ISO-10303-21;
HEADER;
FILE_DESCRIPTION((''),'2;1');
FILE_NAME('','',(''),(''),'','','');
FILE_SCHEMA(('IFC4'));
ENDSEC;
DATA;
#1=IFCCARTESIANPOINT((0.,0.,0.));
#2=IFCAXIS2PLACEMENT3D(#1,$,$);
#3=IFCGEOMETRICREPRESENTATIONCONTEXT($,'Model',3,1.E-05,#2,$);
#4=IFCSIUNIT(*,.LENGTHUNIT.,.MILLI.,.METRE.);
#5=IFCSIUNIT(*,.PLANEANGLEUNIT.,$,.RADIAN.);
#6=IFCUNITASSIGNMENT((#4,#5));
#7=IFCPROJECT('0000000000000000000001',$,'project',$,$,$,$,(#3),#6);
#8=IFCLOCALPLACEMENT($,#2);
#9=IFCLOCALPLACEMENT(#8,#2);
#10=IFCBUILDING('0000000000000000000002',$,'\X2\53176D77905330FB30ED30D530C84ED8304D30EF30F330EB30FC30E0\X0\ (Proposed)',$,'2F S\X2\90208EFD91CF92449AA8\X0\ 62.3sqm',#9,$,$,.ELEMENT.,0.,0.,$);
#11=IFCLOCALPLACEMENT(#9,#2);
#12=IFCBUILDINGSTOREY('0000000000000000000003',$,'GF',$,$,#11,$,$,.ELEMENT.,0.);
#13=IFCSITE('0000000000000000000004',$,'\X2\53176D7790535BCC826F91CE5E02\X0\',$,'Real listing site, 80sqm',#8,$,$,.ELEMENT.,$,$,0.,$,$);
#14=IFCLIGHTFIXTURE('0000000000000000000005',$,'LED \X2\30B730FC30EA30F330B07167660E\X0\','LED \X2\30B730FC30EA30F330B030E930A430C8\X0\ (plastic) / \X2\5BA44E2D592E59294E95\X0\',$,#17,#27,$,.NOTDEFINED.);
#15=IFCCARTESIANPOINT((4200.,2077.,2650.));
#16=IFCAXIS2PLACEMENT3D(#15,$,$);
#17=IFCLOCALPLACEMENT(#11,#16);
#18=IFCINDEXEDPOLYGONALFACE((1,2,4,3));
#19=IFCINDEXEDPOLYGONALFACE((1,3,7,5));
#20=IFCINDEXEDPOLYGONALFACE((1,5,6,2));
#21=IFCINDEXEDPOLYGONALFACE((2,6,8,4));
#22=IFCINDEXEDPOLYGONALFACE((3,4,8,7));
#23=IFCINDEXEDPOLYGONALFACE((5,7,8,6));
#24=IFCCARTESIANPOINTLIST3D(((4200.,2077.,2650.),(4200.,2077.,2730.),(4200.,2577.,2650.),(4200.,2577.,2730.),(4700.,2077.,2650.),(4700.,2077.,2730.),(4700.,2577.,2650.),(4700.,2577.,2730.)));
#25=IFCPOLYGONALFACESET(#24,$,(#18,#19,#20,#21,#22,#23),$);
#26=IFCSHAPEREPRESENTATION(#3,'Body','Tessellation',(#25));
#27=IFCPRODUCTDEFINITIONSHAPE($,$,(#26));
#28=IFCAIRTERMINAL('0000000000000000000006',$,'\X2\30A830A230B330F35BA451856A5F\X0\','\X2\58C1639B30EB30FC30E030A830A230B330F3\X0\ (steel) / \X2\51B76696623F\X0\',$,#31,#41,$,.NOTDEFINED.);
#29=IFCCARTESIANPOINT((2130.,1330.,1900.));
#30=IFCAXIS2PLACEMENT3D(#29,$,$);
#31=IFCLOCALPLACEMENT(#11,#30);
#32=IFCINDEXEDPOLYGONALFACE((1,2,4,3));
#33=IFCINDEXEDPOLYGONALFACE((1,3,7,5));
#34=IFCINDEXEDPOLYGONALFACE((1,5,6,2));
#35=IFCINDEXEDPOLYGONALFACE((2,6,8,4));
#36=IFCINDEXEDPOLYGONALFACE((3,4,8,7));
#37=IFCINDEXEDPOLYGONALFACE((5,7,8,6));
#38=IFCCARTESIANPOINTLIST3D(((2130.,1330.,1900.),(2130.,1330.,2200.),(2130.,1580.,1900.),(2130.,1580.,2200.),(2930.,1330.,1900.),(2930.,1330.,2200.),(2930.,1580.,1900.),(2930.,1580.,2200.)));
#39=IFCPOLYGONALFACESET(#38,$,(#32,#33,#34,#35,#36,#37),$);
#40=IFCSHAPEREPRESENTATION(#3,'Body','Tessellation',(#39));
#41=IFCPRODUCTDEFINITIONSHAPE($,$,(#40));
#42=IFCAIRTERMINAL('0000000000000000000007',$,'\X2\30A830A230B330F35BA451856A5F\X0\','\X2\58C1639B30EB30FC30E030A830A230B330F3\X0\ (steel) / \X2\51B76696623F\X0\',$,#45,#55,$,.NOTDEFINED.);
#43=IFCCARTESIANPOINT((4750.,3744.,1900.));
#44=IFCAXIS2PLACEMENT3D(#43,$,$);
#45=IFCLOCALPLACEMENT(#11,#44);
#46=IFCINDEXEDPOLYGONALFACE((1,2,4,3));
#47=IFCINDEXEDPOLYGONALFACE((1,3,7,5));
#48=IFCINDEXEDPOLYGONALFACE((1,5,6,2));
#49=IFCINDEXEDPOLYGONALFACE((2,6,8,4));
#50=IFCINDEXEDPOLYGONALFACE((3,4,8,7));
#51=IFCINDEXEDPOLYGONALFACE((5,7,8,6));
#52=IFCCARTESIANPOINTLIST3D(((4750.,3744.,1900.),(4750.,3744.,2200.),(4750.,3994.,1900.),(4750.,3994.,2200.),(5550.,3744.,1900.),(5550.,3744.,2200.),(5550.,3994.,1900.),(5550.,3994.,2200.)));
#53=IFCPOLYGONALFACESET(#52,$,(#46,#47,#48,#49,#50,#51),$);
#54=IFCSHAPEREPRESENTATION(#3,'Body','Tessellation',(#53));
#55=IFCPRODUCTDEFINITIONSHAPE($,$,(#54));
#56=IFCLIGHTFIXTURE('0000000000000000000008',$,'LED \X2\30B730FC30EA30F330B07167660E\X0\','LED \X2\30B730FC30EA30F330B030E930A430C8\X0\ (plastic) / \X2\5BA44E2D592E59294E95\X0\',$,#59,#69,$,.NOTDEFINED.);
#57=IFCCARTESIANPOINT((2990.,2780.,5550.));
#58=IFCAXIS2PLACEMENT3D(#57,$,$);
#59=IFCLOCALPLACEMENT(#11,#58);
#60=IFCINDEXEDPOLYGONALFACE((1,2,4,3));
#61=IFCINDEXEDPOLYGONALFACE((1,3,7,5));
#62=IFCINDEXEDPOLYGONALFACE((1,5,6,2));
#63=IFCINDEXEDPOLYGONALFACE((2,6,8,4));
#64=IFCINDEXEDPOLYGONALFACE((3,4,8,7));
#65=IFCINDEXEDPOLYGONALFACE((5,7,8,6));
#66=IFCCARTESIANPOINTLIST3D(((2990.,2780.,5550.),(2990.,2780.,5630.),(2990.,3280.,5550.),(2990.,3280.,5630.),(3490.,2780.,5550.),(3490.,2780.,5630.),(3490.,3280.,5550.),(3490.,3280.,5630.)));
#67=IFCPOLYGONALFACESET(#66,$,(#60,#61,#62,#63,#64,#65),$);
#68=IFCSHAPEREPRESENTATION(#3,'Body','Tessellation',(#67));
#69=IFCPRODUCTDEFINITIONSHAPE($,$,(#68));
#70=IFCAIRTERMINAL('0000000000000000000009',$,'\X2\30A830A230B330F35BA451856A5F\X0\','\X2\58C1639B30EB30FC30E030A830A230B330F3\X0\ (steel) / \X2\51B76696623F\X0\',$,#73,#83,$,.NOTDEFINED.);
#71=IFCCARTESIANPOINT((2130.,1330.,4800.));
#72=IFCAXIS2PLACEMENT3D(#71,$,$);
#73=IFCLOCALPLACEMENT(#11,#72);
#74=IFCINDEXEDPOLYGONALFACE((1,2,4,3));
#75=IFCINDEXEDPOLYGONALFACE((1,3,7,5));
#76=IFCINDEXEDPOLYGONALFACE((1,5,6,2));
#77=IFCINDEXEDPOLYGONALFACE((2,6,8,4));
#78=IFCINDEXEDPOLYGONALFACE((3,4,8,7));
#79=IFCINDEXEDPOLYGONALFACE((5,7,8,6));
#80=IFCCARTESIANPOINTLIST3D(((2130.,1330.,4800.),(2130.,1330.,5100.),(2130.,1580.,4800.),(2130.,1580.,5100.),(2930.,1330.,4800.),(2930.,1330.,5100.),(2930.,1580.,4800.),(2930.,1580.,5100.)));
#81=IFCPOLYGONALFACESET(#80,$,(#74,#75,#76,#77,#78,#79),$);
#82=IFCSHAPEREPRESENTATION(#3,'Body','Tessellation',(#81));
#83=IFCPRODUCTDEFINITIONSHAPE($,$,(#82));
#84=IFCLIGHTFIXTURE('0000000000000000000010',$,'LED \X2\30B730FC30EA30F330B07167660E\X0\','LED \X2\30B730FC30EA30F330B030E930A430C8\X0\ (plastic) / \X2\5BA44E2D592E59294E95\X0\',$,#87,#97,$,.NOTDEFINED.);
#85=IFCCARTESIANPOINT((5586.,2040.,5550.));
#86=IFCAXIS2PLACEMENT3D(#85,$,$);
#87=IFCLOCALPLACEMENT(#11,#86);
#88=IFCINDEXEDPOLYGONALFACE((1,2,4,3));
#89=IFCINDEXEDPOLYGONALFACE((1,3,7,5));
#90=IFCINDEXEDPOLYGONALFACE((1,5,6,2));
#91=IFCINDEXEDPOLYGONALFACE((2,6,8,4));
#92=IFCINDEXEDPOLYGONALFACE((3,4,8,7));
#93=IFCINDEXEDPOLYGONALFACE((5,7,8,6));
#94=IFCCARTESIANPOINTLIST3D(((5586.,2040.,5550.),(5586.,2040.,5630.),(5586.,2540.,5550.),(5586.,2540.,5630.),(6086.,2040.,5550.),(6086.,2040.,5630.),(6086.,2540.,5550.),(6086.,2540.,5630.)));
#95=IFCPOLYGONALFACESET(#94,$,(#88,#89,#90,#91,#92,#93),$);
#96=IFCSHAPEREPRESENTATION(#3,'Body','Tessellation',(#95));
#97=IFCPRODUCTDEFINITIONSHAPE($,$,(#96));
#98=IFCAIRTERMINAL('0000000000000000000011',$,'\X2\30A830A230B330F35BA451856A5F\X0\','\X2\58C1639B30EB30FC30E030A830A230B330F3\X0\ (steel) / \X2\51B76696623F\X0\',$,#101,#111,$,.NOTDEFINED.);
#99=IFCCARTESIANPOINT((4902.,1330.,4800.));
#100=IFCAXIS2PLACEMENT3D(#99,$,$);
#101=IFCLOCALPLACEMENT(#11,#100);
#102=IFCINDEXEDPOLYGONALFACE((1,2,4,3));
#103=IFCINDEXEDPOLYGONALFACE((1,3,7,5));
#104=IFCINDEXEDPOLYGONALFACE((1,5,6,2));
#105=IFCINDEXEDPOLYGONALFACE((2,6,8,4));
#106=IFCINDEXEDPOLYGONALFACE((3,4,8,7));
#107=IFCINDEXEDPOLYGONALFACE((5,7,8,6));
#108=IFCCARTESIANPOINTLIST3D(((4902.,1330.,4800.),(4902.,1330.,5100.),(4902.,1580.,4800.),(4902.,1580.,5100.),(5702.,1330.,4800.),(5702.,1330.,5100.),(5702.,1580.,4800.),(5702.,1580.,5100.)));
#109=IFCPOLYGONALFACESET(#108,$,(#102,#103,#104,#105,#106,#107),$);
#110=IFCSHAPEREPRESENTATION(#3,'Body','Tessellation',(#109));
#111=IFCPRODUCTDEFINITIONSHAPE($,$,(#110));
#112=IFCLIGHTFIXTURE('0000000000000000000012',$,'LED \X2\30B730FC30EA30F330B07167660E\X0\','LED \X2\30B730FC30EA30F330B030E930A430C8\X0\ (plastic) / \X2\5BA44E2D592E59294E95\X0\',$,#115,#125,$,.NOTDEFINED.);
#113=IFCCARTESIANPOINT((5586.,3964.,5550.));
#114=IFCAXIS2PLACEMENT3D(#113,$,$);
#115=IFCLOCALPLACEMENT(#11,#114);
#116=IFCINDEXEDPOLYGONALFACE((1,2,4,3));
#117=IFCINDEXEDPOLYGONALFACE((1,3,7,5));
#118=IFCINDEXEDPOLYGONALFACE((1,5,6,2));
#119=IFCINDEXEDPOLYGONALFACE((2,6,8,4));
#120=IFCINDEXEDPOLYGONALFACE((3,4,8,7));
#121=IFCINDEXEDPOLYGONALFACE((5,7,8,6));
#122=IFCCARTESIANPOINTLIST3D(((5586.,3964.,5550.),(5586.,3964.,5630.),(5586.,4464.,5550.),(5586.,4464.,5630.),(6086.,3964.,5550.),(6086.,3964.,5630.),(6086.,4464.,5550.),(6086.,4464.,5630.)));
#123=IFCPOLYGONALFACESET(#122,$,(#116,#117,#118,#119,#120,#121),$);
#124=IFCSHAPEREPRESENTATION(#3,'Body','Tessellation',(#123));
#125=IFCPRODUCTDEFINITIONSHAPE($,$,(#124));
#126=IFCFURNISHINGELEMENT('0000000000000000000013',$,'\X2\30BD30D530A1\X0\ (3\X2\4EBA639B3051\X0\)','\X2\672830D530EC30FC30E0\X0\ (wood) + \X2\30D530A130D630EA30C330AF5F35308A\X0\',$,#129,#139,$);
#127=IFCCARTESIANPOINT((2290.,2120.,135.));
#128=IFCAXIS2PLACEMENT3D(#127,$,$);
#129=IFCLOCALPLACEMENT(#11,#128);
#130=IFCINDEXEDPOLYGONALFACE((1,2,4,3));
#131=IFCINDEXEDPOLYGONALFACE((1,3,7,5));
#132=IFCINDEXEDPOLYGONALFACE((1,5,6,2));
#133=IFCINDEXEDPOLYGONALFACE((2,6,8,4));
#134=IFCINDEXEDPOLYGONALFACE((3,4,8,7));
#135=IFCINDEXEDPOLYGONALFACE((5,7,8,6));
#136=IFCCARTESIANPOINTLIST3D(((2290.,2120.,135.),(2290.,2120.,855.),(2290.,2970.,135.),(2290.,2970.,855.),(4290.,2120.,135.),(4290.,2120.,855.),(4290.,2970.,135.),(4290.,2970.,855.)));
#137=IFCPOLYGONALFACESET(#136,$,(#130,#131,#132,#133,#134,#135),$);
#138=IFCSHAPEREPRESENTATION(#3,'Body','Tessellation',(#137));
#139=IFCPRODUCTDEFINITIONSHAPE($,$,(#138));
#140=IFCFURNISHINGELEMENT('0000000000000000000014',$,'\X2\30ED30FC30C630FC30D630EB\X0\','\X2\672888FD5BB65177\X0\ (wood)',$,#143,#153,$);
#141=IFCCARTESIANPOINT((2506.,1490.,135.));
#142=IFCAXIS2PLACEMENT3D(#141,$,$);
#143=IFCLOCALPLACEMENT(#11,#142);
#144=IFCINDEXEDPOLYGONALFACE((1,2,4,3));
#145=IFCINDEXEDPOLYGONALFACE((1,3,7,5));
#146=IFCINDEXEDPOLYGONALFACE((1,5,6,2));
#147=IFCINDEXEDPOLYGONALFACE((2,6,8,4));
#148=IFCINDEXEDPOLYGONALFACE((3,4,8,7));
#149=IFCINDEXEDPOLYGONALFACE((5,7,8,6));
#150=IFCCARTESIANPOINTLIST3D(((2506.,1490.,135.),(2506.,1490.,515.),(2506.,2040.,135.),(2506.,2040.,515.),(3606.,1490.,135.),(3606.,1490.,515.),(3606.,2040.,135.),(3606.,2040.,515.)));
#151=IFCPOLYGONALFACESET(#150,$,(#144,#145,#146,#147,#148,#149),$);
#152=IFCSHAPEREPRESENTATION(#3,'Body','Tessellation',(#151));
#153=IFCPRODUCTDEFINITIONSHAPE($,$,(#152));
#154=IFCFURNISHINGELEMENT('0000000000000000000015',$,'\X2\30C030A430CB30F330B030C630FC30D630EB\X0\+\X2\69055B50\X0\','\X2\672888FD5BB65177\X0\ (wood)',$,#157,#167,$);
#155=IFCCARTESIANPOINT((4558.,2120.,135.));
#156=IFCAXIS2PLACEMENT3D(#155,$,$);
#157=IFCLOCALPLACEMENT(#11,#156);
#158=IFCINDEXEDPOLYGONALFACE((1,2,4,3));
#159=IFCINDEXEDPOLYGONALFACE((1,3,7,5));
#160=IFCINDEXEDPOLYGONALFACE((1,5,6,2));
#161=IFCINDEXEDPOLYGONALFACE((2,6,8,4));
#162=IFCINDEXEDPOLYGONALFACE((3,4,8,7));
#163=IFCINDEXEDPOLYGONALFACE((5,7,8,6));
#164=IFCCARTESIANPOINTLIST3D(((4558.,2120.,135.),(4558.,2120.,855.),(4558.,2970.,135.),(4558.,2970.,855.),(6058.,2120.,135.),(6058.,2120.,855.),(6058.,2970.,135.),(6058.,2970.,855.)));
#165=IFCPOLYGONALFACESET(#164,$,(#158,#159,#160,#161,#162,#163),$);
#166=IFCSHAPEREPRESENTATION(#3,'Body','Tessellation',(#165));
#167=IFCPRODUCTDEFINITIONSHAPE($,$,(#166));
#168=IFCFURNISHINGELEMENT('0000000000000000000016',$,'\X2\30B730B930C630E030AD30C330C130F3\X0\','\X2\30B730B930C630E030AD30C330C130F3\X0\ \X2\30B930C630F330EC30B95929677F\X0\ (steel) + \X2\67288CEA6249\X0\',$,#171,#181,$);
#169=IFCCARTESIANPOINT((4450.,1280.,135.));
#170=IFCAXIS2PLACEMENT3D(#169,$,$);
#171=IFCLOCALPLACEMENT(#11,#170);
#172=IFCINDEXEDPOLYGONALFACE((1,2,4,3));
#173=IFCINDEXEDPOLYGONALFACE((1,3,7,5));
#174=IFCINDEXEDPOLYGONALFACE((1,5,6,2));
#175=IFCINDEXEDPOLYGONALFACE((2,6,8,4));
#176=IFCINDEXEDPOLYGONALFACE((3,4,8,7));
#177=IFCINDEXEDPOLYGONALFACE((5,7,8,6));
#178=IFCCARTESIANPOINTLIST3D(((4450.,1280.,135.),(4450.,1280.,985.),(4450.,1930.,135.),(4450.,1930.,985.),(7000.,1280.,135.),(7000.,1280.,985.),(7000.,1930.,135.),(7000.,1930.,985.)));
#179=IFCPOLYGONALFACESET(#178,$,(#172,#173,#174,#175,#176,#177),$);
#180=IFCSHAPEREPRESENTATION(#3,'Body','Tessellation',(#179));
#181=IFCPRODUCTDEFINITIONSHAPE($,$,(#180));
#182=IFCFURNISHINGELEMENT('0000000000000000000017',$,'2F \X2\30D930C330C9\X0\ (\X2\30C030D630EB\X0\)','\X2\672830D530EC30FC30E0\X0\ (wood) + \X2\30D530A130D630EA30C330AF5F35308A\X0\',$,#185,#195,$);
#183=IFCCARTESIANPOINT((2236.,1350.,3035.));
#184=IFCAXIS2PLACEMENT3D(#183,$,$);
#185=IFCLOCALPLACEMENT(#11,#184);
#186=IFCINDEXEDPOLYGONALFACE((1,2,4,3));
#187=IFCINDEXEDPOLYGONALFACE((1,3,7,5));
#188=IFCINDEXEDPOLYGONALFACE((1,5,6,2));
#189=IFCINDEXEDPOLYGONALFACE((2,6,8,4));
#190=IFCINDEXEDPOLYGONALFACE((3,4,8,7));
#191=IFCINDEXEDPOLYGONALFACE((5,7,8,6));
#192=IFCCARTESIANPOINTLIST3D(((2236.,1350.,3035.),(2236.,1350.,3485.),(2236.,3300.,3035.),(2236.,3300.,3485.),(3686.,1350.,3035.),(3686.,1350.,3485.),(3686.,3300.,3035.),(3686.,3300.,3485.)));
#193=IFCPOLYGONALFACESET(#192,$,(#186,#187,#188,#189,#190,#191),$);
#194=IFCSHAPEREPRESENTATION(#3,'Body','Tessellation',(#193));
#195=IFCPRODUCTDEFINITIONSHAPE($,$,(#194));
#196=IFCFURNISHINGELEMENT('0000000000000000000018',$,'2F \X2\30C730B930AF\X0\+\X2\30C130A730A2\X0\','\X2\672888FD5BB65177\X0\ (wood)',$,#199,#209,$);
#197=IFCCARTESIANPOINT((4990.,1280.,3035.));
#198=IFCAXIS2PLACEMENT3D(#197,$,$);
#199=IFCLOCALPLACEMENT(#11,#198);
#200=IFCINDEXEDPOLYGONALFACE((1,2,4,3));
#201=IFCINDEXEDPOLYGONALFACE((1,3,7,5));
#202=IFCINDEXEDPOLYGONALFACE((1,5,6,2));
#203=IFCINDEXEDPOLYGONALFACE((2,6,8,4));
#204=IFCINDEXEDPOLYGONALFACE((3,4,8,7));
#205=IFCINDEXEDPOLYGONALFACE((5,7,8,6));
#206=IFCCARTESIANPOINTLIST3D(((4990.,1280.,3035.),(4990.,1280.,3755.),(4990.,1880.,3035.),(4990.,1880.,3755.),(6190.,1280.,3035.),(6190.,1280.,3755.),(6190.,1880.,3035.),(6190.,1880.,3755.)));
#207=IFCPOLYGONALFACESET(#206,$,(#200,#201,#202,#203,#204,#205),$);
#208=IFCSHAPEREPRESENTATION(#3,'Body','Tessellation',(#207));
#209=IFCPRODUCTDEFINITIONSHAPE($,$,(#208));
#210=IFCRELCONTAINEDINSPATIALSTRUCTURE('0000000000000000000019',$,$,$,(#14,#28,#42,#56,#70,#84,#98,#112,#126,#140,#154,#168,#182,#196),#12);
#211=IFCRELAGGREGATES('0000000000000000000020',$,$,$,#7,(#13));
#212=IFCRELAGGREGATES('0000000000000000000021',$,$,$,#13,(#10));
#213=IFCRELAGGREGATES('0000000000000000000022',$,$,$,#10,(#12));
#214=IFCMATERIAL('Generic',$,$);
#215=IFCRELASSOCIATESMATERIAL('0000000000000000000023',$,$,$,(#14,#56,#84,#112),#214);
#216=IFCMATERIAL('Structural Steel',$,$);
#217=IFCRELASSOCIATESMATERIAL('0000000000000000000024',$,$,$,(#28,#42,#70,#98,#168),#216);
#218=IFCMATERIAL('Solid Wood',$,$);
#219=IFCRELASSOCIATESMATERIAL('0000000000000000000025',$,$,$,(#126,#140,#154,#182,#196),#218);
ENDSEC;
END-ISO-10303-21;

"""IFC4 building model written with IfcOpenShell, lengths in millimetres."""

from ifc_helpers import new_model, si_unit, frame, frame_2d, origin, place, context, project, spatial, rectangle, extrude, material, element, save


model = new_model("IFC4")

# Units and contexts
model_context = context("Model", 3, precision=1e-05, world=origin())
ifc_project = project(units=[si_unit("LENGTHUNIT", "METRE", prefix="MILLI"), si_unit("PLANEANGLEUNIT", "RADIAN")], contexts=[model_context])

# Site, building, storey
site_placement = place(None, origin())
site = spatial("IfcSite", under=ifc_project, at=site_placement, Name="北海道富良野市", ObjectType="Real listing site, 80sqm", CompositionType="ELEMENT", RefElevation=0.0)
building_placement = place(site_placement, origin())
building = spatial("IfcBuilding", under=site, at=building_placement, Name="北海道・ロフト付きワンルーム (Proposed)", ObjectType="2F S造軽量鉄骨 62.3sqm", CompositionType="ELEMENT", ElevationOfRefHeight=0.0, ElevationOfTerrain=0.0)
storey_placement = place(building_placement, origin())
storey = spatial("IfcBuildingStorey", under=building, at=storey_placement, Name="GF", CompositionType="ELEMENT", Elevation=0.0)

# Shared definitions
ifc_material_1 = material(Name="Solid Wood")

# Shared definitions
ifc_material_2 = material(Name="Structural Steel")

# Shared definitions
ifc_material_3 = material(Name="Generic")

# Light fixture
light_fixture_1_placement = place(storey_placement, frame((4200.0, 2077.0, 2650.0)))
element("IfcLightFixture", 1, at=light_fixture_1_placement, inside=storey, material=ifc_material_3, Name="LED シーリング照明", Description="LED シーリングライト (plastic) / 室中央天井", PredefinedType="NOTDEFINED", context=model_context, shape_type="SweptSolid", body=[
    extrude(rectangle(XDim=500.0, YDim=500.0, at=frame_2d((250.0, 250.0))), frame((4200.0, 2077.0, 2650.0)), (0.0, 0.0, 1.0), 80.0),
])

# Air terminals
air_terminal_1_placement = place(storey_placement, frame((2130.0, 1330.0, 1900.0)))
element("IfcAirTerminal", 2, at=air_terminal_1_placement, inside=storey, material=ifc_material_2, Name="エアコン室内機", Description="壁掛ルームエアコン (steel) / 冷暖房", PredefinedType="NOTDEFINED", context=model_context, shape_type="SweptSolid", body=[
    extrude(rectangle(XDim=800.0, YDim=250.0, at=frame_2d((400.0, 125.0))), frame((2130.0, 1330.0, 1900.0)), (0.0, 0.0, 1.0), 300.0),
])
air_terminal_2_placement = place(storey_placement, frame((4750.0, 3744.0, 1900.0)))
element("IfcAirTerminal", 3, at=air_terminal_2_placement, inside=storey, material=ifc_material_2, Name="エアコン室内機", Description="壁掛ルームエアコン (steel) / 冷暖房", PredefinedType="NOTDEFINED", context=model_context, shape_type="SweptSolid", body=[
    extrude(rectangle(XDim=800.0, YDim=250.0, at=frame_2d((400.0, 125.0))), frame((4750.0, 3744.0, 1900.0)), (0.0, 0.0, 1.0), 300.0),
])

# Light fixture
light_fixture_2_placement = place(storey_placement, frame((2990.0, 2780.0, 5550.0)))
element("IfcLightFixture", 4, at=light_fixture_2_placement, inside=storey, material=ifc_material_3, Name="LED シーリング照明", Description="LED シーリングライト (plastic) / 室中央天井", PredefinedType="NOTDEFINED", context=model_context, shape_type="SweptSolid", body=[
    extrude(rectangle(XDim=500.0, YDim=500.0, at=frame_2d((250.0, 250.0))), frame((2990.0, 2780.0, 5550.0)), (0.0, 0.0, 1.0), 80.0),
])

# Air terminal
air_terminal_3_placement = place(storey_placement, frame((2130.0, 1330.0, 4800.0)))
element("IfcAirTerminal", 5, at=air_terminal_3_placement, inside=storey, material=ifc_material_2, Name="エアコン室内機", Description="壁掛ルームエアコン (steel) / 冷暖房", PredefinedType="NOTDEFINED", context=model_context, shape_type="SweptSolid", body=[
    extrude(rectangle(XDim=800.0, YDim=250.0, at=frame_2d((400.0, 125.0))), frame((2130.0, 1330.0, 4800.0)), (0.0, 0.0, 1.0), 300.0),
])

# Light fixture
light_fixture_3_placement = place(storey_placement, frame((5586.0, 2040.0, 5550.0)))
element("IfcLightFixture", 6, at=light_fixture_3_placement, inside=storey, material=ifc_material_3, Name="LED シーリング照明", Description="LED シーリングライト (plastic) / 室中央天井", PredefinedType="NOTDEFINED", context=model_context, shape_type="SweptSolid", body=[
    extrude(rectangle(XDim=500.0, YDim=500.0, at=frame_2d((250.0, 250.0))), frame((5586.0, 2040.0, 5550.0)), (0.0, 0.0, 1.0), 80.0),
])

# Air terminal
air_terminal_4_placement = place(storey_placement, frame((4902.0, 1330.0, 4800.0)))
element("IfcAirTerminal", 7, at=air_terminal_4_placement, inside=storey, material=ifc_material_2, Name="エアコン室内機", Description="壁掛ルームエアコン (steel) / 冷暖房", PredefinedType="NOTDEFINED", context=model_context, shape_type="SweptSolid", body=[
    extrude(rectangle(XDim=800.0, YDim=250.0, at=frame_2d((400.0, 125.0))), frame((4902.0, 1330.0, 4800.0)), (0.0, 0.0, 1.0), 300.0),
])

# Light fixture
light_fixture_4_placement = place(storey_placement, frame((5586.0, 3964.0, 5550.0)))
element("IfcLightFixture", 8, at=light_fixture_4_placement, inside=storey, material=ifc_material_3, Name="LED シーリング照明", Description="LED シーリングライト (plastic) / 室中央天井", PredefinedType="NOTDEFINED", context=model_context, shape_type="SweptSolid", body=[
    extrude(rectangle(XDim=500.0, YDim=500.0, at=frame_2d((250.0, 250.0))), frame((5586.0, 3964.0, 5550.0)), (0.0, 0.0, 1.0), 80.0),
])

# Furnishing elements
furnishing_1_placement = place(storey_placement, frame((2290.0, 2120.0, 135.0)))
element("IfcFurnishingElement", 9, at=furnishing_1_placement, inside=storey, material=ifc_material_1, Name="ソファ (3人掛け)", Description="木フレーム (wood) + ファブリック張り", context=model_context, shape_type="SweptSolid", body=[
    extrude(rectangle(XDim=2000.0, YDim=850.0, at=frame_2d((1000.0, 425.0))), frame((2290.0, 2120.0, 135.0)), (0.0, 0.0, 1.0), 720.0),
])
furnishing_2_placement = place(storey_placement, frame((2506.0, 1490.0, 135.0)))
element("IfcFurnishingElement", 10, at=furnishing_2_placement, inside=storey, material=ifc_material_1, Name="ローテーブル", Description="木製家具 (wood)", context=model_context, shape_type="SweptSolid", body=[
    extrude(rectangle(XDim=1100.0, YDim=550.0, at=frame_2d((550.0, 275.0))), frame((2506.0, 1490.0, 135.0)), (0.0, 0.0, 1.0), 380.0),
])
furnishing_3_placement = place(storey_placement, frame((4558.0, 2120.0, 135.0)))
element("IfcFurnishingElement", 11, at=furnishing_3_placement, inside=storey, material=ifc_material_1, Name="ダイニングテーブル+椅子", Description="木製家具 (wood)", context=model_context, shape_type="SweptSolid", body=[
    extrude(rectangle(XDim=1500.0, YDim=850.0, at=frame_2d((750.0, 425.0))), frame((4558.0, 2120.0, 135.0)), (0.0, 0.0, 1.0), 720.0),
])
furnishing_4_placement = place(storey_placement, frame((4450.0, 1280.0, 135.0)))
element("IfcFurnishingElement", 12, at=furnishing_4_placement, inside=storey, material=ifc_material_2, Name="システムキッチン", Description="システムキッチン ステンレス天板 (steel) + 木質扉", context=model_context, shape_type="SweptSolid", body=[
    extrude(rectangle(XDim=2550.0, YDim=650.0, at=frame_2d((1275.0, 325.0))), frame((4450.0, 1280.0, 135.0)), (0.0, 0.0, 1.0), 850.0),
])
furnishing_5_placement = place(storey_placement, frame((2236.0, 1350.0, 3035.0)))
element("IfcFurnishingElement", 13, at=furnishing_5_placement, inside=storey, material=ifc_material_1, Name="2F ベッド (ダブル)", Description="木フレーム (wood) + ファブリック張り", context=model_context, shape_type="SweptSolid", body=[
    extrude(rectangle(XDim=1450.0, YDim=1950.0, at=frame_2d((725.0, 975.0))), frame((2236.0, 1350.0, 3035.0)), (0.0, 0.0, 1.0), 450.0),
])
furnishing_6_placement = place(storey_placement, frame((4990.0, 1280.0, 3035.0)))
element("IfcFurnishingElement", 14, at=furnishing_6_placement, inside=storey, material=ifc_material_1, Name="2F デスク+チェア", Description="木製家具 (wood)", context=model_context, shape_type="SweptSolid", body=[
    extrude(rectangle(XDim=1200.0, YDim=600.0, at=frame_2d((600.0, 300.0))), frame((4990.0, 1280.0, 3035.0)), (0.0, 0.0, 1.0), 720.0),
])

save(model, "model.ifc")
